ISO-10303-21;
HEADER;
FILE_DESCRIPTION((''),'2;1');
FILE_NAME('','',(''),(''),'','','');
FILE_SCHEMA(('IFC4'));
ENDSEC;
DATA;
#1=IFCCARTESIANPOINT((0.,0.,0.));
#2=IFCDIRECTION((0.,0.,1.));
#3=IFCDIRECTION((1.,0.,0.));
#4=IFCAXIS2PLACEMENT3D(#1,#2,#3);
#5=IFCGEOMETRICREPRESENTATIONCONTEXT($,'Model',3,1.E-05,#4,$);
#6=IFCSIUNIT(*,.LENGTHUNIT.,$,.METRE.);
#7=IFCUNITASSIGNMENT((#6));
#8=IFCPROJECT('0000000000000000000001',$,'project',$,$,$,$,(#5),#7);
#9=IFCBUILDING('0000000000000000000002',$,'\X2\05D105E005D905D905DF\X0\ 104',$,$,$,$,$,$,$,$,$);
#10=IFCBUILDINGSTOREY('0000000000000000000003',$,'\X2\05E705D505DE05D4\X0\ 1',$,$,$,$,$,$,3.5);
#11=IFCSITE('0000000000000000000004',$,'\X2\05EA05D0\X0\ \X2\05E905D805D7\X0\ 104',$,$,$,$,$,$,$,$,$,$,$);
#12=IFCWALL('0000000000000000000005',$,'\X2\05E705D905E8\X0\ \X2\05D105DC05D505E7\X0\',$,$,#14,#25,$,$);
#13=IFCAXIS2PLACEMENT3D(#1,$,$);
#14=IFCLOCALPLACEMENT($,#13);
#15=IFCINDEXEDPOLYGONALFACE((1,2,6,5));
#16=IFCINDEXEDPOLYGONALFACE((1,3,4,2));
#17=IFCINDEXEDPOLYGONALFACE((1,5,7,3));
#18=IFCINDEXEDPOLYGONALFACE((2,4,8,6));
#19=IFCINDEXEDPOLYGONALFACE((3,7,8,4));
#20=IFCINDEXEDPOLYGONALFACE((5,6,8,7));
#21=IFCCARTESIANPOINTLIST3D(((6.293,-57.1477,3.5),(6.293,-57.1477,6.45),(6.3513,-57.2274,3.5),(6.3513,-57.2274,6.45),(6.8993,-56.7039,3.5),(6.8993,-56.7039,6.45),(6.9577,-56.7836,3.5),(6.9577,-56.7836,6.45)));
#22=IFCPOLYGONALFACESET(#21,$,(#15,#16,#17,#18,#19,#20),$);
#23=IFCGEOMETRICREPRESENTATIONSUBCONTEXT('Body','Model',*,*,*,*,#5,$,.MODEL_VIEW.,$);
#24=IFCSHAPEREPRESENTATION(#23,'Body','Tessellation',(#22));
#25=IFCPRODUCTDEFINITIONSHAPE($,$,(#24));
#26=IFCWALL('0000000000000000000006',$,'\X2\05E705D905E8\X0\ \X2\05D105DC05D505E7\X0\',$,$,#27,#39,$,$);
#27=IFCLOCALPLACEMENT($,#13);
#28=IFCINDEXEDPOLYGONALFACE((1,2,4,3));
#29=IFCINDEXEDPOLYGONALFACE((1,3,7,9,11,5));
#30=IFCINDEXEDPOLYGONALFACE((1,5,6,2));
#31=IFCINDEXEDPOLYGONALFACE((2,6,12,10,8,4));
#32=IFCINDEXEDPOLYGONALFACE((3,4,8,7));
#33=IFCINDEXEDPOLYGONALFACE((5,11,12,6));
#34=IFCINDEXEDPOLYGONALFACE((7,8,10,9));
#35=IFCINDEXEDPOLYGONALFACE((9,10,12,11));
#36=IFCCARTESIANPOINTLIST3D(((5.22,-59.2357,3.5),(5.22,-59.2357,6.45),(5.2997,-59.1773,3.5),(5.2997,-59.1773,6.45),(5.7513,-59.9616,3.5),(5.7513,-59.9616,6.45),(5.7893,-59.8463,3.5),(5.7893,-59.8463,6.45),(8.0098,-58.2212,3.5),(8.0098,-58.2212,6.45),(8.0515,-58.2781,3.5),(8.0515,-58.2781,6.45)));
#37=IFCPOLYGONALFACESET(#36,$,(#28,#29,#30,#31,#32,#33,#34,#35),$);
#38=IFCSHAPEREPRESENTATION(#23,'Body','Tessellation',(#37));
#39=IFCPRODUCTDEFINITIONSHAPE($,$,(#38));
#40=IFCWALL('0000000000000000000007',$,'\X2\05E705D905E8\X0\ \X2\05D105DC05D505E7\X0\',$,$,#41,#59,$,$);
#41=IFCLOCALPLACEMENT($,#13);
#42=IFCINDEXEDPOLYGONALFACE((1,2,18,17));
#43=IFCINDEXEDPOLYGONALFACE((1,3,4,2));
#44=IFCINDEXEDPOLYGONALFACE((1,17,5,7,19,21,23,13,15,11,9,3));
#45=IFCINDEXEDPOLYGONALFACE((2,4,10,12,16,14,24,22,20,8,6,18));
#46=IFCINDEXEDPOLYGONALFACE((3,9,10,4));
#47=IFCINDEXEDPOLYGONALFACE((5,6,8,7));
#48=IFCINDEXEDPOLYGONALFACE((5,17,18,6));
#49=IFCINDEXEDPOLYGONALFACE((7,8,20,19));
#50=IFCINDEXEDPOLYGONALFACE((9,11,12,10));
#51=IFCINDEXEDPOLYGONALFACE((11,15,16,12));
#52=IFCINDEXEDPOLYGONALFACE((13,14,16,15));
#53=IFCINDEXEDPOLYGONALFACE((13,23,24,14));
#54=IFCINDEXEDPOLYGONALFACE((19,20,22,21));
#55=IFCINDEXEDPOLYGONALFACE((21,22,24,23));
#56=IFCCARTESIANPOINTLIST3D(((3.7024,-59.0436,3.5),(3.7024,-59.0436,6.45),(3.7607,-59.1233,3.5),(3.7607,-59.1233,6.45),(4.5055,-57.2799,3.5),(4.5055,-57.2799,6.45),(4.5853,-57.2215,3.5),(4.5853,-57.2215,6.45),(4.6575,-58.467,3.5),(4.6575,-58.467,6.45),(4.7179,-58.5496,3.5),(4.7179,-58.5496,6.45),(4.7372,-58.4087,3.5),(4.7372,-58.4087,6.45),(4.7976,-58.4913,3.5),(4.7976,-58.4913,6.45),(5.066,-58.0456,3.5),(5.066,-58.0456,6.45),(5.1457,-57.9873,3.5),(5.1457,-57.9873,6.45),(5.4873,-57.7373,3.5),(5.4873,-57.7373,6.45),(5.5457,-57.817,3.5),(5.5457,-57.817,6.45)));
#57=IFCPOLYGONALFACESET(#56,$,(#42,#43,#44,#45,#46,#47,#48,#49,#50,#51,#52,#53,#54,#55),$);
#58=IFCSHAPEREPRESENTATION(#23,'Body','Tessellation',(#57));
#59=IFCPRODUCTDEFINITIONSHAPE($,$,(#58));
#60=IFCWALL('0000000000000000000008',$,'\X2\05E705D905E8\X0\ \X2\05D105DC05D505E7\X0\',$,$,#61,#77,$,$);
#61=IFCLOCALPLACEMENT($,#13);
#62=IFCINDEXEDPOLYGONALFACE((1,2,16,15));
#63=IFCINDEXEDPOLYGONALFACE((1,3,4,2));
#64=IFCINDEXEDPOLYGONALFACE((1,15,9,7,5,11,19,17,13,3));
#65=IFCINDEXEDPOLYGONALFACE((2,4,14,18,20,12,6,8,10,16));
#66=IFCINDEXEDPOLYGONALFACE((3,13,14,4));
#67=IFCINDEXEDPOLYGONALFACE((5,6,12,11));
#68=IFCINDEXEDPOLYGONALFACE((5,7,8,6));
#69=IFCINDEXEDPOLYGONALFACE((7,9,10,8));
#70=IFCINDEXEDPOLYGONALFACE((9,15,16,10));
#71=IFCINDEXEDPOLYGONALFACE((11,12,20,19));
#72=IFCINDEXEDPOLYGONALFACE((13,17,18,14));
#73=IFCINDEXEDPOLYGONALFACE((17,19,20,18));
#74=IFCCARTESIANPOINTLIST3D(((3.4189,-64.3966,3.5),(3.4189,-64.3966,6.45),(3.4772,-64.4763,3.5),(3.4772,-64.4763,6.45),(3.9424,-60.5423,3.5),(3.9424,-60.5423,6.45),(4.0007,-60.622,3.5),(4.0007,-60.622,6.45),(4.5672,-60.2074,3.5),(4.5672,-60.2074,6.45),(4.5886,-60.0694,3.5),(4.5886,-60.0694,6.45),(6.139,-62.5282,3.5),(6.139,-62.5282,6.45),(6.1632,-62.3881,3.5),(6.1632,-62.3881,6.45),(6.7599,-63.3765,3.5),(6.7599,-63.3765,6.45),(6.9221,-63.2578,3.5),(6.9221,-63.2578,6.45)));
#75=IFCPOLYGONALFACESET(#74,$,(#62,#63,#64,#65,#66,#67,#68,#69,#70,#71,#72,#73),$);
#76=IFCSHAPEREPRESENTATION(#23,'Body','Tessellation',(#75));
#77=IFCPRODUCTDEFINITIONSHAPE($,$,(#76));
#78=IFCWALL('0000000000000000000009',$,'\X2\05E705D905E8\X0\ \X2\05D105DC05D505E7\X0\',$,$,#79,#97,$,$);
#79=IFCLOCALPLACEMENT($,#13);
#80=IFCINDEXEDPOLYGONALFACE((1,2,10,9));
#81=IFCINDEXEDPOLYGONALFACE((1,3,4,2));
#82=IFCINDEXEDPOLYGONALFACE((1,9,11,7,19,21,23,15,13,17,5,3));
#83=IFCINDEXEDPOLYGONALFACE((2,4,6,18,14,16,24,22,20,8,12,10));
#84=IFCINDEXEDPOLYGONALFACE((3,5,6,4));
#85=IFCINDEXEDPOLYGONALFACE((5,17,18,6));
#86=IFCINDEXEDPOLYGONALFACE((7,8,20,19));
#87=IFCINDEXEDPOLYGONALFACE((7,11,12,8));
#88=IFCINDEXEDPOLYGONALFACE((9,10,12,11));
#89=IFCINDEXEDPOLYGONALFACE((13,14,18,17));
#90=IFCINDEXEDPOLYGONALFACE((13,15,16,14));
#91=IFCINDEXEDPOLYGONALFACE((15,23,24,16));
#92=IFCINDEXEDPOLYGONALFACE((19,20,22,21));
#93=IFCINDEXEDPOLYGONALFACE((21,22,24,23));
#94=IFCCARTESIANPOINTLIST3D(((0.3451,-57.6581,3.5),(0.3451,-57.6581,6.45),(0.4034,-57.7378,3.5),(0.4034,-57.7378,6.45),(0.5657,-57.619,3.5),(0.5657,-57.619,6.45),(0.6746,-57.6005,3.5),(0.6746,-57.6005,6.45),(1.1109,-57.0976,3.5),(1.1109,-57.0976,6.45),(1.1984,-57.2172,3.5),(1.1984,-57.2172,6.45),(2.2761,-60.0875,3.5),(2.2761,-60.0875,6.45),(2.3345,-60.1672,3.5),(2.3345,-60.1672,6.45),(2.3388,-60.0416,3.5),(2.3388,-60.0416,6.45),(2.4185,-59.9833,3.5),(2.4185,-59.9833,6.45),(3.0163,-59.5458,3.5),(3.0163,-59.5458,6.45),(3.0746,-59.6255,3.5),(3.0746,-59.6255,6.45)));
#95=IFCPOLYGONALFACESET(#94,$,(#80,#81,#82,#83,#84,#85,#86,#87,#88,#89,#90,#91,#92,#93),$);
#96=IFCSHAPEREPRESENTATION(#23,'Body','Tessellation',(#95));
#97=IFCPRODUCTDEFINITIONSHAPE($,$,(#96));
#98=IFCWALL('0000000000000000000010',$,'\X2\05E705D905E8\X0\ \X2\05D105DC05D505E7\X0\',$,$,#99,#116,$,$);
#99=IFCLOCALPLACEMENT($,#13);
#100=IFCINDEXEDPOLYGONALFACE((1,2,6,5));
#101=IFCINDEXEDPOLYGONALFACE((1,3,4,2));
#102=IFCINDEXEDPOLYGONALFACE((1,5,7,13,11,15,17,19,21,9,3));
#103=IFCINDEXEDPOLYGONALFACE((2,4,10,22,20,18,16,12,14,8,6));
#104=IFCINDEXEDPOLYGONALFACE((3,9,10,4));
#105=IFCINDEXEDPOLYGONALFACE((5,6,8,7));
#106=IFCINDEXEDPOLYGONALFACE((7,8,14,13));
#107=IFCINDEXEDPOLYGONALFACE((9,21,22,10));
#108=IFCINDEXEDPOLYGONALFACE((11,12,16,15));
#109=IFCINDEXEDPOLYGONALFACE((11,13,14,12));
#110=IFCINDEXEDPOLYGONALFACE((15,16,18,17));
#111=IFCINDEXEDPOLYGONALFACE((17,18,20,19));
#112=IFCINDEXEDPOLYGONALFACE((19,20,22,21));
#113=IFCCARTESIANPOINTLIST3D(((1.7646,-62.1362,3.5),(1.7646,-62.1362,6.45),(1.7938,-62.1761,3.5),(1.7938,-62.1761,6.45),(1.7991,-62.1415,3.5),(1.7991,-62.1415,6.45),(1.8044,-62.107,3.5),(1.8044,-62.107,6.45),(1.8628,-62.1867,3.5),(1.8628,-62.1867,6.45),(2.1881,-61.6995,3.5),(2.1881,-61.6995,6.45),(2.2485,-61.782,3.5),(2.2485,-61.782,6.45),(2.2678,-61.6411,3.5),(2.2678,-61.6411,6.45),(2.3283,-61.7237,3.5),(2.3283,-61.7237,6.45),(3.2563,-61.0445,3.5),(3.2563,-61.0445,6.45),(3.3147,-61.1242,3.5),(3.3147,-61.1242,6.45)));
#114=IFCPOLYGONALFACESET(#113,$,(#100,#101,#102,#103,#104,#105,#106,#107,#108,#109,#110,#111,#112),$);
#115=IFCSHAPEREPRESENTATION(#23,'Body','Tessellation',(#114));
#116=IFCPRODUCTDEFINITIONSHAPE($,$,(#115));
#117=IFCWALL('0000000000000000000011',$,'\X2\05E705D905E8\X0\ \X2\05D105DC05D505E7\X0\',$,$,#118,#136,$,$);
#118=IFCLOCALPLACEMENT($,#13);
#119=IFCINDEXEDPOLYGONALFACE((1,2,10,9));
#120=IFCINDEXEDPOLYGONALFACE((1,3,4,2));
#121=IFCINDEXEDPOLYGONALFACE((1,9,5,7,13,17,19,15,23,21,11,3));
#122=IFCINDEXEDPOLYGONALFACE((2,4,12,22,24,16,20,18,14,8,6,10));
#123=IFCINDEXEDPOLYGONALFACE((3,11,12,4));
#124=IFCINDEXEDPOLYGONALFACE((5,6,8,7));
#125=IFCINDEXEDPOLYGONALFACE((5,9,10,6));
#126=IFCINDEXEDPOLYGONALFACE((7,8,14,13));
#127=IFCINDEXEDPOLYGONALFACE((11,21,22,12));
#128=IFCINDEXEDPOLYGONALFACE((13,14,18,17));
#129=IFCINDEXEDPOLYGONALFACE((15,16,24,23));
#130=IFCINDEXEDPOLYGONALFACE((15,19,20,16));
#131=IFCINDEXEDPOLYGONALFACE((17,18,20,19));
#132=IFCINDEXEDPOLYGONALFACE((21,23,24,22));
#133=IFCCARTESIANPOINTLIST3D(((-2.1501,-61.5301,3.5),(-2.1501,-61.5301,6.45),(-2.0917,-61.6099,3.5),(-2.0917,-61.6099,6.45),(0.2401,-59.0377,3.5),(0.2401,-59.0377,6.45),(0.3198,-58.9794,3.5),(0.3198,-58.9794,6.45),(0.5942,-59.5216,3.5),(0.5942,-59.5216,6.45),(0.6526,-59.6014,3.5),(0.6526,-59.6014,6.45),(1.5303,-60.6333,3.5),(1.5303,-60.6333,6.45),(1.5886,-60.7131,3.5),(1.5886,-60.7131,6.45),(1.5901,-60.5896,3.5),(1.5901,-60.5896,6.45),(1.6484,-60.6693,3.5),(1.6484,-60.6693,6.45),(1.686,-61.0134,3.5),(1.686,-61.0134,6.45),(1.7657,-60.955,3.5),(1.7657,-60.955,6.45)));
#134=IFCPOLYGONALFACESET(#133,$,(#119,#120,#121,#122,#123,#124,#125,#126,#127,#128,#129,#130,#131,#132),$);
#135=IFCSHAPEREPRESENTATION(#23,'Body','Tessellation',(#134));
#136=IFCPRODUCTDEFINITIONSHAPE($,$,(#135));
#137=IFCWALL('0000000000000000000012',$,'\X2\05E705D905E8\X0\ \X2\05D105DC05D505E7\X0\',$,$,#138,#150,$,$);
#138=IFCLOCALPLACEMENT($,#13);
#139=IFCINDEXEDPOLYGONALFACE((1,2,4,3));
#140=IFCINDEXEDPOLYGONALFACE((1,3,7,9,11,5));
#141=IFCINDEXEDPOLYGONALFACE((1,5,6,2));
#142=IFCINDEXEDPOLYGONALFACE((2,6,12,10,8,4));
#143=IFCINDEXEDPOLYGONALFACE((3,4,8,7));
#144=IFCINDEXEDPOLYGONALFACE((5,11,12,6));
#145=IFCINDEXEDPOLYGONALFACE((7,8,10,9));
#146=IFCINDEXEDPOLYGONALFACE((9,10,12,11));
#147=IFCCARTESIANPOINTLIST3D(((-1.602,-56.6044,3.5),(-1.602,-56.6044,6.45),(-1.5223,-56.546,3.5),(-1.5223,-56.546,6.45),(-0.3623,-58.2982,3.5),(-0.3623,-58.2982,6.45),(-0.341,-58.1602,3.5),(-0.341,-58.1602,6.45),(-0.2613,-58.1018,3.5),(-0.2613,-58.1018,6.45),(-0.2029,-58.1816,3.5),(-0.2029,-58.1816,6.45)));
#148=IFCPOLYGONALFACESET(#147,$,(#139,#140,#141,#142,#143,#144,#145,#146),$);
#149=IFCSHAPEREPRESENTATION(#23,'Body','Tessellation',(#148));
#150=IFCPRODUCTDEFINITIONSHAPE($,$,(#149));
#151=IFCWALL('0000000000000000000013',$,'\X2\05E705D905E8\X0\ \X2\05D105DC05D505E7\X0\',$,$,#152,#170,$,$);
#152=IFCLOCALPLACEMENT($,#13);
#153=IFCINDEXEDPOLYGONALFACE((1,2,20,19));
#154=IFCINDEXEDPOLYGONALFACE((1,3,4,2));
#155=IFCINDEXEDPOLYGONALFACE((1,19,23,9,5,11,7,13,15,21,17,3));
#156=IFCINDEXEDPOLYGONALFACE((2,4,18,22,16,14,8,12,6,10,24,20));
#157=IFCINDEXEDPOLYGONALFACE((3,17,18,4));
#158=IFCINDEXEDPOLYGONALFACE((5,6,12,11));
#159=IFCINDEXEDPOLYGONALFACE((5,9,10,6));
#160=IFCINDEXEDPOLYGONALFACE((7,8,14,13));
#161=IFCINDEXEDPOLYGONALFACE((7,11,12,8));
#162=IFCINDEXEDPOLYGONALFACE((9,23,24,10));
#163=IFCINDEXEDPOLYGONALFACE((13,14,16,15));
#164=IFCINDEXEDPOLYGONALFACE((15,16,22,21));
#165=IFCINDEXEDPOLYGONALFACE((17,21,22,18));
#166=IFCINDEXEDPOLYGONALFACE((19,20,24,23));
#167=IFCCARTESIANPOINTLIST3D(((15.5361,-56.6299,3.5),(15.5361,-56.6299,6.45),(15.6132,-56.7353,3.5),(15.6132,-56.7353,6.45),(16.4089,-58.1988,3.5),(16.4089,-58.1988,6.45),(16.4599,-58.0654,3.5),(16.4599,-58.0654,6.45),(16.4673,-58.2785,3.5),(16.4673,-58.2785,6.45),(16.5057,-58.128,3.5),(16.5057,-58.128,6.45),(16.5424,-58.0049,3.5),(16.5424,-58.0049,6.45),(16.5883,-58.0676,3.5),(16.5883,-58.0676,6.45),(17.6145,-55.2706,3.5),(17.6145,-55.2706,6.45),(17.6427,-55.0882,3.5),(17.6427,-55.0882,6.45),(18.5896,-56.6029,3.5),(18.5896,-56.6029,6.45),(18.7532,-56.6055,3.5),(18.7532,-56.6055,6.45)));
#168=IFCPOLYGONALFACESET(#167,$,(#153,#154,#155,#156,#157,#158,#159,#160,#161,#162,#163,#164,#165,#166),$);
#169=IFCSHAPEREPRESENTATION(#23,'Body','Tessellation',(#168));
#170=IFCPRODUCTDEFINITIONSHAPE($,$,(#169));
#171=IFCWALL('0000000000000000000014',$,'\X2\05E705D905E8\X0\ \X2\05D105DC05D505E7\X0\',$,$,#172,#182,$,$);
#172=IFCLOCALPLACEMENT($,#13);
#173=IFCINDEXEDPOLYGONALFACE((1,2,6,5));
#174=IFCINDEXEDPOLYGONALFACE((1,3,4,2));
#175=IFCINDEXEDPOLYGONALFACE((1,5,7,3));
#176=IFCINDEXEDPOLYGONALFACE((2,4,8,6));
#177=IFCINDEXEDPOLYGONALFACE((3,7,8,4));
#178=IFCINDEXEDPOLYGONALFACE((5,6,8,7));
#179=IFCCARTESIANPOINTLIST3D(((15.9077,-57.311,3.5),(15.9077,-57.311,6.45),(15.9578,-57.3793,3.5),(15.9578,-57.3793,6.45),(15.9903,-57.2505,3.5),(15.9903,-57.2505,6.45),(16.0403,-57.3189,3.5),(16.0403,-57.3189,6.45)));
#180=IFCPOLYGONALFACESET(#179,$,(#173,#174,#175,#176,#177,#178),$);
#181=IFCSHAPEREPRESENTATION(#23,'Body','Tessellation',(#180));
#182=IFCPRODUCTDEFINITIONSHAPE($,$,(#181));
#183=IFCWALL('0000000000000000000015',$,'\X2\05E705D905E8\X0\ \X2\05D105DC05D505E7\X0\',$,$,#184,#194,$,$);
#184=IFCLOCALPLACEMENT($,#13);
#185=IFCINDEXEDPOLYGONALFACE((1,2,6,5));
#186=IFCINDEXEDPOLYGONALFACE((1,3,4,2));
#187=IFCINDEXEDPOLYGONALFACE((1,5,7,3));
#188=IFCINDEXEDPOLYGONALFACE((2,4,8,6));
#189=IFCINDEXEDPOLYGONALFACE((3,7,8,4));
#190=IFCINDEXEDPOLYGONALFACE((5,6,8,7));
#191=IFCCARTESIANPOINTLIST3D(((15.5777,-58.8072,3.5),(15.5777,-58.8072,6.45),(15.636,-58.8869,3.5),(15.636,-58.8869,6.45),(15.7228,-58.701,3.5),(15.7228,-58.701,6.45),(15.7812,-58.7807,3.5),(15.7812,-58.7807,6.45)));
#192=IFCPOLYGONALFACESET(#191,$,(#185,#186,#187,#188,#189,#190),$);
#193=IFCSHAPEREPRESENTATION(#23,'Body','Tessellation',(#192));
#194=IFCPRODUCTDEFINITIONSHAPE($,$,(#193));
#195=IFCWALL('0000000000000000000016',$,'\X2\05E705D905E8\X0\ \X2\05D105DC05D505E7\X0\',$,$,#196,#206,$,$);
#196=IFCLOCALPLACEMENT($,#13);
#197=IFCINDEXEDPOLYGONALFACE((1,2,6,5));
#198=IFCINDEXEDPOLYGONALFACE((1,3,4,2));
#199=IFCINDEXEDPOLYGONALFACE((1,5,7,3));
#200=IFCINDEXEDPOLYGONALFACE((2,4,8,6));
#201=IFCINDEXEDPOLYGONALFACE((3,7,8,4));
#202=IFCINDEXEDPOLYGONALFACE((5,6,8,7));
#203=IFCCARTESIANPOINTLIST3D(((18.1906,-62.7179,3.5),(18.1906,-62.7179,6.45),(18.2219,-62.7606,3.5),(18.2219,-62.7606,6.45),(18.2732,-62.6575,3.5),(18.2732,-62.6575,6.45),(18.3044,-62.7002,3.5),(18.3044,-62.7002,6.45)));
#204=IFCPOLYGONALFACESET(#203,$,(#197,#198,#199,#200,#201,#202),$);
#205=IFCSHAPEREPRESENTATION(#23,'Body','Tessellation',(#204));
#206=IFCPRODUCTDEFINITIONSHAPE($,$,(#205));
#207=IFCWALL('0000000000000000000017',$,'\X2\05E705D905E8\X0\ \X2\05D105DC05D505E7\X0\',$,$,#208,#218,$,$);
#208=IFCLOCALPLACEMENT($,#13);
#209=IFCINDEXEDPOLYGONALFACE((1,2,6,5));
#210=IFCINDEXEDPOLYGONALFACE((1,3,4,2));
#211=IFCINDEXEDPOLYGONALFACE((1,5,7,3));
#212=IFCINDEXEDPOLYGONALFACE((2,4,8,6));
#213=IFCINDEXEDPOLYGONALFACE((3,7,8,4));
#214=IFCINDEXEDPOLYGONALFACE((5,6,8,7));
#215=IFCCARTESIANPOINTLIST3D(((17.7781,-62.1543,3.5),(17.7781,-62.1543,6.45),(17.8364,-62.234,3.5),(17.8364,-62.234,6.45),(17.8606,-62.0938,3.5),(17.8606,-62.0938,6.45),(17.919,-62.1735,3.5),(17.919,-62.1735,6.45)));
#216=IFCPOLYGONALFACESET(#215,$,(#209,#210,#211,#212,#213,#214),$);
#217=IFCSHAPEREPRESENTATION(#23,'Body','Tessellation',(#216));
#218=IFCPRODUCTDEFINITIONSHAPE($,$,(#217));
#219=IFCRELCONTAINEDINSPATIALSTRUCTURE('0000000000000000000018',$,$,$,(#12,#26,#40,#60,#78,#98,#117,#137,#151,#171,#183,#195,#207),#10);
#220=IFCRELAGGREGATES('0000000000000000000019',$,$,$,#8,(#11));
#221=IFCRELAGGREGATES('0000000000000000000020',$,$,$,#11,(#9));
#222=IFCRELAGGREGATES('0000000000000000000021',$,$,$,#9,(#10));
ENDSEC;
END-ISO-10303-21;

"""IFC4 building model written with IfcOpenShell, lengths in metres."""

from ifc_helpers import new_model, si_unit, frame, origin_with_axes, context, subcontext, project, spatial, polyline, outline, extrude, element, save


model = new_model("IFC4")

# Units and contexts
model_context = context("Model", 3, precision=1e-05, world=origin_with_axes())
body_context = subcontext(model_context, "Body", "Model", "MODEL_VIEW")
ifc_project = project(units=[si_unit("LENGTHUNIT", "METRE")], contexts=[model_context])

# Site, building, storey
site = spatial("IfcSite", under=ifc_project, Name="תא שטח 104")
building = spatial("IfcBuilding", under=site, Name="בניין 104")
storey = spatial("IfcBuildingStorey", under=building, Name="קומה 1", Elevation=3.5)

# Walls
element("IfcWall", 1, inside=storey, Name="קיר בלוק", context=body_context, shape_type="SweptSolid", body=[
    extrude(outline(polyline([(6.3513, -57.2274), (6.9577, -56.7836), (6.8993, -56.7039), (6.293, -57.1477), (6.3513, -57.2274)])), frame((0.0, 0.0, 3.5)), (0.0, 0.0, 1.0), 2.95),
])
element("IfcWall", 2, inside=storey, Name="קיר בלוק", context=body_context, shape_type="SweptSolid", body=[
    extrude(outline(polyline([(5.22, -59.2357), (5.7513, -59.9616), (8.0515, -58.2781), (8.0098, -58.2212), (5.7893, -59.8463), (5.2997, -59.1773), (5.22, -59.2357)])), frame((0.0, 0.0, 3.5)), (0.0, 0.0, 1.0), 2.95),
])
element("IfcWall", 3, inside=storey, Name="קיר בלוק", context=body_context, shape_type="SweptSolid", body=[
    extrude(outline(polyline([(3.7024, -59.0436), (3.7607, -59.1233), (4.6575, -58.467), (4.7179, -58.5496), (4.7976, -58.4913), (4.7372, -58.4087), (5.5457, -57.817), (5.4873, -57.7373), (5.1457, -57.9873), (4.5853, -57.2215), (4.5055, -57.2799), (5.066, -58.0456), (3.7024, -59.0436)])), frame((0.0, 0.0, 3.5)), (0.0, 0.0, 1.0), 2.95),
])
element("IfcWall", 4, inside=storey, Name="קיר בלוק", context=body_context, shape_type="SweptSolid", body=[
    extrude(outline(polyline([(4.0007, -60.622), (4.5672, -60.2074), (6.1632, -62.3881), (3.4189, -64.3966), (3.4772, -64.4763), (6.139, -62.5282), (6.7599, -63.3765), (6.9221, -63.2578), (4.5886, -60.0694), (3.9424, -60.5423), (4.0007, -60.622)])), frame((0.0, 0.0, 3.5)), (0.0, 0.0, 1.0), 2.95),
])
element("IfcWall", 5, inside=storey, Name="קיר בלוק", context=body_context, shape_type="SweptSolid", body=[
    extrude(outline(polyline([(1.1109, -57.0976), (0.3451, -57.6581), (0.4034, -57.7378), (0.5657, -57.619), (2.3388, -60.0416), (2.2761, -60.0875), (2.3345, -60.1672), (3.0746, -59.6255), (3.0163, -59.5458), (2.4185, -59.9833), (0.6746, -57.6005), (1.1984, -57.2172), (1.1109, -57.0976)])), frame((0.0, 0.0, 3.5)), (0.0, 0.0, 1.0), 2.95),
])
element("IfcWall", 6, inside=storey, Name="קיר בלוק", context=body_context, shape_type="SweptSolid", body=[
    extrude(outline(polyline([(2.2485, -61.782), (1.8044, -62.107), (1.7991, -62.1415), (1.7646, -62.1362), (1.7938, -62.1761), (1.8628, -62.1867), (3.3147, -61.1242), (3.2563, -61.0445), (2.3283, -61.7237), (2.2678, -61.6411), (2.1881, -61.6995), (2.2485, -61.782)])), frame((0.0, 0.0, 3.5)), (0.0, 0.0, 1.0), 2.95),
])
element("IfcWall", 7, inside=storey, Name="קיר בלוק", context=body_context, shape_type="SweptSolid", body=[
    extrude(outline(polyline([(-2.1501, -61.5301), (-2.0917, -61.6099), (0.6526, -59.6014), (1.686, -61.0134), (1.7657, -60.955), (1.5886, -60.7131), (1.6484, -60.6693), (1.5901, -60.5896), (1.5303, -60.6333), (0.3198, -58.9794), (0.2401, -59.0377), (0.5942, -59.5216), (-2.1501, -61.5301)])), frame((0.0, 0.0, 3.5)), (0.0, 0.0, 1.0), 2.95),
])
element("IfcWall", 8, inside=storey, Name="קיר בלוק", context=body_context, shape_type="SweptSolid", body=[
    extrude(outline(polyline([(-1.602, -56.6044), (-0.3623, -58.2982), (-0.2029, -58.1816), (-0.2613, -58.1018), (-0.341, -58.1602), (-1.5223, -56.546), (-1.602, -56.6044)])), frame((0.0, 0.0, 3.5)), (0.0, 0.0, 1.0), 2.95),
])
element("IfcWall", 9, inside=storey, Name="קיר בלוק", context=body_context, shape_type="SweptSolid", body=[
    extrude(outline(polyline([(15.6132, -56.7353), (17.6145, -55.2706), (18.5896, -56.6029), (16.5883, -58.0676), (16.5424, -58.0049), (16.4599, -58.0654), (16.5057, -58.128), (16.4089, -58.1988), (16.4673, -58.2785), (18.7532, -56.6055), (17.6427, -55.0882), (15.5361, -56.6299), (15.6132, -56.7353)])), frame((0.0, 0.0, 3.5)), (0.0, 0.0, 1.0), 2.95),
])
element("IfcWall", 10, inside=storey, Name="קיר בלוק", context=body_context, shape_type="SweptSolid", body=[
    extrude(outline(polyline([(15.9077, -57.311), (15.9578, -57.3793), (16.0403, -57.3189), (15.9903, -57.2505), (15.9077, -57.311)])), frame((0.0, 0.0, 3.5)), (0.0, 0.0, 1.0), 2.95),
])
element("IfcWall", 11, inside=storey, Name="קיר בלוק", context=body_context, shape_type="SweptSolid", body=[
    extrude(outline(polyline([(15.7812, -58.7807), (15.7228, -58.701), (15.5777, -58.8072), (15.636, -58.8869), (15.7812, -58.7807)])), frame((0.0, 0.0, 3.5)), (0.0, 0.0, 1.0), 2.95),
])
element("IfcWall", 12, inside=storey, Name="קיר בלוק", context=body_context, shape_type="SweptSolid", body=[
    extrude(outline(polyline([(18.3044, -62.7002), (18.2732, -62.6575), (18.1906, -62.7179), (18.2219, -62.7606), (18.3044, -62.7002)])), frame((0.0, 0.0, 3.5)), (0.0, 0.0, 1.0), 2.95),
])
element("IfcWall", 13, inside=storey, Name="קיר בלוק", context=body_context, shape_type="SweptSolid", body=[
    extrude(outline(polyline([(17.919, -62.1735), (17.8606, -62.0938), (17.7781, -62.1543), (17.8364, -62.234), (17.919, -62.1735)])), frame((0.0, 0.0, 3.5)), (0.0, 0.0, 1.0), 2.95),
])

save(model, "model.ifc")
